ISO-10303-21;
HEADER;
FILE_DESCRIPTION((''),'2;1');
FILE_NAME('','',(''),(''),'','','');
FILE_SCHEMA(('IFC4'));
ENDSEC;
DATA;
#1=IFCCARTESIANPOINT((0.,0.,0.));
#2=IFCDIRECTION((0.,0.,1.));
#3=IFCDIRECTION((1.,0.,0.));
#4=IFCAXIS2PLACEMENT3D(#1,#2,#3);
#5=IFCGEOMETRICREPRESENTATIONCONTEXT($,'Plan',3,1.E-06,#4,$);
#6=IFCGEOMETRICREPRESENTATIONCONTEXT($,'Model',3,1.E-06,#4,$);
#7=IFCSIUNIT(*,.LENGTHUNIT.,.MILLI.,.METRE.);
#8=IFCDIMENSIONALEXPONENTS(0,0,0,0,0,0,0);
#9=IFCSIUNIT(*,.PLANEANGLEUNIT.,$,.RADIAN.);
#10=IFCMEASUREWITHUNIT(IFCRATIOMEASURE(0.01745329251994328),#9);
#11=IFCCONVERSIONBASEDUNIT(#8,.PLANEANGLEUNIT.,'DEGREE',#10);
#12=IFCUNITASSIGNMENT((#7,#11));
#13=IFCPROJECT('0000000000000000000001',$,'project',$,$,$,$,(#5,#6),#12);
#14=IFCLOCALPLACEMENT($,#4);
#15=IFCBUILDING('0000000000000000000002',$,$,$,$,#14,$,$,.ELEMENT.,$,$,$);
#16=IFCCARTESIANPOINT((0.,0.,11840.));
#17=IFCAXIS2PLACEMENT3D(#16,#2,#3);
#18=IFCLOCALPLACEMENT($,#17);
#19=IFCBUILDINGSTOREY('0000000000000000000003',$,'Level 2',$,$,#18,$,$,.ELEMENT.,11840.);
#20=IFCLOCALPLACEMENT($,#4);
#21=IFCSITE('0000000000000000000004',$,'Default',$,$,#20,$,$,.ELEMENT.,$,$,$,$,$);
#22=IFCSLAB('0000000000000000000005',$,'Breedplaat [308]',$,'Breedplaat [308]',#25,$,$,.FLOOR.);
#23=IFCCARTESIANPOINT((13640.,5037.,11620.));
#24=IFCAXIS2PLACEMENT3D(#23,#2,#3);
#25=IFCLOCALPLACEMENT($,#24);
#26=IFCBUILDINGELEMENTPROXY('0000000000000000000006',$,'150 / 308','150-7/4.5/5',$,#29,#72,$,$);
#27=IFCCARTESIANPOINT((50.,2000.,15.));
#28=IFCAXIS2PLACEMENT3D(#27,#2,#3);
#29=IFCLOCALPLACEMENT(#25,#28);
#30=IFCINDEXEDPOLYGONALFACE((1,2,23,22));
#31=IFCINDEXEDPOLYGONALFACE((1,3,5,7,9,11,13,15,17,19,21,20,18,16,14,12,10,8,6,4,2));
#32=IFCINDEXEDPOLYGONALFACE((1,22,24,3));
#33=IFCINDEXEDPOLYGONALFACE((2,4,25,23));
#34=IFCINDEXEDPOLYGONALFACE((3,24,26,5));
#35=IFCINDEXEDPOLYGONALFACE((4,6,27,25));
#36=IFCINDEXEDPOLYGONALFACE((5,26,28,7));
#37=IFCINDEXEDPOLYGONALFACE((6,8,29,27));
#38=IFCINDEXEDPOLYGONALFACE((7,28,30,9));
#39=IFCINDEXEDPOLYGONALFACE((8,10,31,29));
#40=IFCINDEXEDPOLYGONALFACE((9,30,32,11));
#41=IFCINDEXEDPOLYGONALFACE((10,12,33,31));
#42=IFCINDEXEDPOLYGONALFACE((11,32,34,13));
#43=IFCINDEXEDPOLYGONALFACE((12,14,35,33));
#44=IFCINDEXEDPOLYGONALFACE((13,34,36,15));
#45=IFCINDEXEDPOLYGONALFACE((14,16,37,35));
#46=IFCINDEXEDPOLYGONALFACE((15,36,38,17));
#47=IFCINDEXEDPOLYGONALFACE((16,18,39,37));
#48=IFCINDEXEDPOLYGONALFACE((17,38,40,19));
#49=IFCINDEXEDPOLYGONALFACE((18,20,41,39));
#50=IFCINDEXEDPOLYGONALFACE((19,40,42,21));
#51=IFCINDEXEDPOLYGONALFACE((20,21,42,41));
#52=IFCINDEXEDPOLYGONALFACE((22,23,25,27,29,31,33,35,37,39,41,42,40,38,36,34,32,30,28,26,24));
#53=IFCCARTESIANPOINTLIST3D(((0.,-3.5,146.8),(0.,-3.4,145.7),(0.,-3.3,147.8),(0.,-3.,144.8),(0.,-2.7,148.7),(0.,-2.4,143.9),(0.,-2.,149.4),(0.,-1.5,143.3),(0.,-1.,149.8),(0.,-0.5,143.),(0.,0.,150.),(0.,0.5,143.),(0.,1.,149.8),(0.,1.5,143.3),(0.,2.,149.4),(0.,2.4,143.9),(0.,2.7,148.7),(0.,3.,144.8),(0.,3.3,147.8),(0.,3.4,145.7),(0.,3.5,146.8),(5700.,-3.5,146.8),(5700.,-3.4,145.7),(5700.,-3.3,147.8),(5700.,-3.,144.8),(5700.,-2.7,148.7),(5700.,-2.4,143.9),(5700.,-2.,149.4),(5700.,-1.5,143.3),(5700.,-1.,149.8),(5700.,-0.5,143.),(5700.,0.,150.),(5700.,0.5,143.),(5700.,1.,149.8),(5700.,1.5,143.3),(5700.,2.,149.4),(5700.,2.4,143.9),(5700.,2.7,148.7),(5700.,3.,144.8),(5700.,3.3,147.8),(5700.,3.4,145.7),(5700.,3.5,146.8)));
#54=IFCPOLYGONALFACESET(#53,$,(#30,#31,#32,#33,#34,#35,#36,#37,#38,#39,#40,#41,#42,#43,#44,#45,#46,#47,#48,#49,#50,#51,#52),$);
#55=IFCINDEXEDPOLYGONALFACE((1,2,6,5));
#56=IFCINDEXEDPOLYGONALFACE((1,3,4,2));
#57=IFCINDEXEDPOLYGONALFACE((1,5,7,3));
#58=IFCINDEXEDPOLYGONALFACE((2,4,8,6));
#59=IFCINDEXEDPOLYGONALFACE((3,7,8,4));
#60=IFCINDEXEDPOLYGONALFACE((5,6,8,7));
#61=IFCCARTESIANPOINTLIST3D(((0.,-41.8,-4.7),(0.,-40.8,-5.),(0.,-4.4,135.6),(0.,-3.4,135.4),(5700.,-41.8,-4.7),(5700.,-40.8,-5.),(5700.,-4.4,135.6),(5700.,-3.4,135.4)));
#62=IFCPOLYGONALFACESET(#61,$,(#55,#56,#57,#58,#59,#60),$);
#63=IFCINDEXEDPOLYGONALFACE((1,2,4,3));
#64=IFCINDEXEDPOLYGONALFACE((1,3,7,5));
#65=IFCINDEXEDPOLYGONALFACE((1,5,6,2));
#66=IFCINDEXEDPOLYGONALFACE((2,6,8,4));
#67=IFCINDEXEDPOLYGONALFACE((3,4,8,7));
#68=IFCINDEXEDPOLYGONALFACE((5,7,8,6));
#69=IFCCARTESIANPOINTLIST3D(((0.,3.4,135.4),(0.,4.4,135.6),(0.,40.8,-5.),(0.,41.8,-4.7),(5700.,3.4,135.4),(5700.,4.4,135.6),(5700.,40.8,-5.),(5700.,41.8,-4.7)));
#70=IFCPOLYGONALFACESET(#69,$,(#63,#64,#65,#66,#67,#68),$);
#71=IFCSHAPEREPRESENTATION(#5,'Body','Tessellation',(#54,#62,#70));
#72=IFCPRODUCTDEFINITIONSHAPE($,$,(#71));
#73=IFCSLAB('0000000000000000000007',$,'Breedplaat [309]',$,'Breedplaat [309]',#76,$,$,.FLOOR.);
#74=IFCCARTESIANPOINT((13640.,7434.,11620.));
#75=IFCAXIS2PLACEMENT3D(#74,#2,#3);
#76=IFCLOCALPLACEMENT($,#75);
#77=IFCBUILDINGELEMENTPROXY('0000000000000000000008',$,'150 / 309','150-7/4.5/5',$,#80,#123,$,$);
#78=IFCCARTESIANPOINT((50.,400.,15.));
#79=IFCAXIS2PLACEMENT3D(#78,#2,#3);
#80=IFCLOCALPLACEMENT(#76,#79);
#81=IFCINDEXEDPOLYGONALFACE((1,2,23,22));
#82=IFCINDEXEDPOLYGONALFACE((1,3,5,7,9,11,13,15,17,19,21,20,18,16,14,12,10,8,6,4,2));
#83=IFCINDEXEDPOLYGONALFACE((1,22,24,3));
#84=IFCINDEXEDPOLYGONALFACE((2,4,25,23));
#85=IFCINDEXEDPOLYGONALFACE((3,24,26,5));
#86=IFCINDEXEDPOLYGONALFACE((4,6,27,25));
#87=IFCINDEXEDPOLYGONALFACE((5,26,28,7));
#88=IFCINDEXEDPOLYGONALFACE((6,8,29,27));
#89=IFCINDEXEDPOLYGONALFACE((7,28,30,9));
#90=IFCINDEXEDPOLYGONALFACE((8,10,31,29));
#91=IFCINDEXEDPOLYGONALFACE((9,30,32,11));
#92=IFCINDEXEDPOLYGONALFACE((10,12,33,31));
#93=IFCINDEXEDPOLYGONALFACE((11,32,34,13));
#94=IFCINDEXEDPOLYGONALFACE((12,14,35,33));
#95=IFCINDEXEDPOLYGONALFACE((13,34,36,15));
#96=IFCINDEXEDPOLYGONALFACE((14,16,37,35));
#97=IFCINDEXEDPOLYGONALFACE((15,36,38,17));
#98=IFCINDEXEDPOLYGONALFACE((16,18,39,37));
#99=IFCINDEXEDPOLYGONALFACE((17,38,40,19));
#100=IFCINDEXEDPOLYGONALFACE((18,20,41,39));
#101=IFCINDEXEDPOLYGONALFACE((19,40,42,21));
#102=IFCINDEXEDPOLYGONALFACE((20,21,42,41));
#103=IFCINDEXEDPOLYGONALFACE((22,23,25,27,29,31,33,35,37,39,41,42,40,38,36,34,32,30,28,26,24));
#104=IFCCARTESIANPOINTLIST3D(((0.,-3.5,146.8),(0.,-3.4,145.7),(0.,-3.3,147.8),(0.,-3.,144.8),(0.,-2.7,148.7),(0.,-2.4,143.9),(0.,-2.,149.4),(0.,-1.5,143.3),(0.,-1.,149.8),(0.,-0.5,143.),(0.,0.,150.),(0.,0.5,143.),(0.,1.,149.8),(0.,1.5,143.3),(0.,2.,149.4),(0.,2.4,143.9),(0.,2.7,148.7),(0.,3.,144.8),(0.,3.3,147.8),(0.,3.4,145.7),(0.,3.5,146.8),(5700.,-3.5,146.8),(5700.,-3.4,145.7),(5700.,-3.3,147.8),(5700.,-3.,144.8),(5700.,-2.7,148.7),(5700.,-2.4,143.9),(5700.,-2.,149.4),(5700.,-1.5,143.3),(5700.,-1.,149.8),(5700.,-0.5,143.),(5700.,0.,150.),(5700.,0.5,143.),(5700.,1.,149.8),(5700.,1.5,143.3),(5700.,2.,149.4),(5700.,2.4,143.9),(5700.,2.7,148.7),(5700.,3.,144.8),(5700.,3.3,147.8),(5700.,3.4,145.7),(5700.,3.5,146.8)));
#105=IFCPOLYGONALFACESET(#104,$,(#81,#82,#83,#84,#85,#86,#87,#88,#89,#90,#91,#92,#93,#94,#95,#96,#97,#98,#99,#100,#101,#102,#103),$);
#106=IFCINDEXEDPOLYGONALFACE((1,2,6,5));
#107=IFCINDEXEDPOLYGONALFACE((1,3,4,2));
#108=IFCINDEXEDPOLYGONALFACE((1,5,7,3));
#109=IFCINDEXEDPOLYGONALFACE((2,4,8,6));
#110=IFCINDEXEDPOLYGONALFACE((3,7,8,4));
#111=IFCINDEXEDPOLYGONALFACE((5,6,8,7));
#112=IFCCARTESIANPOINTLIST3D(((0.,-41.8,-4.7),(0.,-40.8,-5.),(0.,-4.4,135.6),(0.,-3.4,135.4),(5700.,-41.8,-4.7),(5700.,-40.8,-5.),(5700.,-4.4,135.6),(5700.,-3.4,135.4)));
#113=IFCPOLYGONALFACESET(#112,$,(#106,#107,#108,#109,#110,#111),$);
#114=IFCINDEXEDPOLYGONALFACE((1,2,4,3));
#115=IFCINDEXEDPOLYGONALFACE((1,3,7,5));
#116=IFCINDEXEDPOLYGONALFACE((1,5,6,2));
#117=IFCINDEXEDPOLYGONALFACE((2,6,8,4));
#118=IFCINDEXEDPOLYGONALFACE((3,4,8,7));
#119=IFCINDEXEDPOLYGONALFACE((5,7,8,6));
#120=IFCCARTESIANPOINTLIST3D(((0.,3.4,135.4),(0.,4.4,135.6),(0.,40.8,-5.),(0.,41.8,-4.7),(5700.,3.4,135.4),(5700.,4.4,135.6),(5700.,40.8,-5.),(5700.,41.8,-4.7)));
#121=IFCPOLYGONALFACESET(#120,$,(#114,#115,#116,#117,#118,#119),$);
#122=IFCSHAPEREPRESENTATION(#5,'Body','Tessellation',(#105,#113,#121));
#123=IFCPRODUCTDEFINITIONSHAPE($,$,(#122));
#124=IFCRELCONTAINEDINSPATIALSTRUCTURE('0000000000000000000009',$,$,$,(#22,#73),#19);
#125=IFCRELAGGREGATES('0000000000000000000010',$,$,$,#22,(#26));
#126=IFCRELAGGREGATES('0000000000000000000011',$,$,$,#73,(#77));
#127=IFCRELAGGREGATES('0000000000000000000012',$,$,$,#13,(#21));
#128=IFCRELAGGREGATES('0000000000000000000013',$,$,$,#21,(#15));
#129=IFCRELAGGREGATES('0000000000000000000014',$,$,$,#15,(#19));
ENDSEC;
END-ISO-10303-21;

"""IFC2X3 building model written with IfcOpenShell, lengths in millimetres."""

from ifc_helpers import new_model, entity, si_unit, converted_unit, frame, origin_with_axes, origin_2d_with_axis, place, context, project, spatial, rectangle, circle, extrude, element, aggregate, save


model = new_model("IFC2X3")

# Units and contexts
plan_context = context("Plan", 3, precision=1e-06, world=origin_with_axes())
model_context = context("Model", 3, precision=1e-06, world=origin_with_axes())
ifc_project = project(units=[si_unit("LENGTHUNIT", "METRE", prefix="MILLI"), converted_unit("PLANEANGLEUNIT", "DEGREE", entity("IfcRatioMeasure", 0.01745329251994328), si_unit("PLANEANGLEUNIT", "RADIAN"), dimensions=[0, 0, 0, 0, 0, 0, 0])], contexts=[plan_context, model_context])

# Site, building, storey
site_placement = place(None, origin_with_axes())
site = spatial("IfcSite", under=ifc_project, at=site_placement, Name="Default", CompositionType="ELEMENT")
building_placement = place(None, origin_with_axes())
building = spatial("IfcBuilding", under=site, at=building_placement, CompositionType="ELEMENT")
storey_placement = place(None, frame((0.0, 0.0, 11840.0), z_axis=(0.0, 0.0, 1.0), x_axis=(1.0, 0.0, 0.0)))
storey = spatial("IfcBuildingStorey", under=building, at=storey_placement, Name="Level 2", CompositionType="ELEMENT", Elevation=11840.0)

# Slabs, building element proxies
slab_1_placement = place(None, frame((13640.0, 5037.0, 11620.0), z_axis=(0.0, 0.0, 1.0), x_axis=(1.0, 0.0, 0.0)))
slab_1 = element("IfcSlab", 1, at=slab_1_placement, inside=storey, Name="Breedplaat [308]", ObjectType="Breedplaat [308]", PredefinedType="FLOOR")
proxy_1_placement = place(slab_1_placement, frame((50.0, 2000.0, 15.0), z_axis=(0.0, 0.0, 1.0), x_axis=(1.0, 0.0, 0.0)))
proxy_1 = element("IfcBuildingElementProxy", 2, at=proxy_1_placement, Name="150 / 308", Description="150-7/4.5/5", context=plan_context, shape_type="SweptSolid", body=[
    extrude(circle(Radius=3.5, at=origin_2d_with_axis()), frame((0.0, 0.0, 146.5), z_axis=(1.0, 0.0, 0.0), x_axis=(0.0, 0.0, 1.0)), (0.0, 0.0, 1.0), 5700.0),
    extrude(rectangle(XDim=145.2, YDim=1.0, at=origin_2d_with_axis()), frame((0.0, -22.6, 65.3), z_axis=(1.0, 0.0, 0.0), x_axis=(0.0, 0.257663, 0.966235)), (0.0, 0.0, 1.0), 5700.0),
    extrude(rectangle(XDim=145.2, YDim=1.0, at=origin_2d_with_axis()), frame((0.0, 22.6, 65.3), z_axis=(1.0, 0.0, 0.0), x_axis=(0.0, -0.257663, 0.966235)), (0.0, 0.0, 1.0), 5700.0),
])
aggregate(slab_1, [proxy_1])
slab_2_placement = place(None, frame((13640.0, 7434.0, 11620.0), z_axis=(0.0, 0.0, 1.0), x_axis=(1.0, 0.0, 0.0)))
slab_2 = element("IfcSlab", 3, at=slab_2_placement, inside=storey, Name="Breedplaat [309]", ObjectType="Breedplaat [309]", PredefinedType="FLOOR")
proxy_2_placement = place(slab_2_placement, frame((50.0, 400.0, 15.0), z_axis=(0.0, 0.0, 1.0), x_axis=(1.0, 0.0, 0.0)))
proxy_2 = element("IfcBuildingElementProxy", 4, at=proxy_2_placement, Name="150 / 309", Description="150-7/4.5/5", context=plan_context, shape_type="SweptSolid", body=[
    extrude(circle(Radius=3.5, at=origin_2d_with_axis()), frame((0.0, 0.0, 146.5), z_axis=(1.0, 0.0, 0.0), x_axis=(0.0, 0.0, 1.0)), (0.0, 0.0, 1.0), 5700.0),
    extrude(rectangle(XDim=145.2, YDim=1.0, at=origin_2d_with_axis()), frame((0.0, -22.6, 65.3), z_axis=(1.0, 0.0, 0.0), x_axis=(0.0, 0.257663, 0.966235)), (0.0, 0.0, 1.0), 5700.0),
    extrude(rectangle(XDim=145.2, YDim=1.0, at=origin_2d_with_axis()), frame((0.0, 22.6, 65.3), z_axis=(1.0, 0.0, 0.0), x_axis=(0.0, -0.257663, 0.966235)), (0.0, 0.0, 1.0), 5700.0),
])
aggregate(slab_2, [proxy_2])

save(model, "model.ifc")
